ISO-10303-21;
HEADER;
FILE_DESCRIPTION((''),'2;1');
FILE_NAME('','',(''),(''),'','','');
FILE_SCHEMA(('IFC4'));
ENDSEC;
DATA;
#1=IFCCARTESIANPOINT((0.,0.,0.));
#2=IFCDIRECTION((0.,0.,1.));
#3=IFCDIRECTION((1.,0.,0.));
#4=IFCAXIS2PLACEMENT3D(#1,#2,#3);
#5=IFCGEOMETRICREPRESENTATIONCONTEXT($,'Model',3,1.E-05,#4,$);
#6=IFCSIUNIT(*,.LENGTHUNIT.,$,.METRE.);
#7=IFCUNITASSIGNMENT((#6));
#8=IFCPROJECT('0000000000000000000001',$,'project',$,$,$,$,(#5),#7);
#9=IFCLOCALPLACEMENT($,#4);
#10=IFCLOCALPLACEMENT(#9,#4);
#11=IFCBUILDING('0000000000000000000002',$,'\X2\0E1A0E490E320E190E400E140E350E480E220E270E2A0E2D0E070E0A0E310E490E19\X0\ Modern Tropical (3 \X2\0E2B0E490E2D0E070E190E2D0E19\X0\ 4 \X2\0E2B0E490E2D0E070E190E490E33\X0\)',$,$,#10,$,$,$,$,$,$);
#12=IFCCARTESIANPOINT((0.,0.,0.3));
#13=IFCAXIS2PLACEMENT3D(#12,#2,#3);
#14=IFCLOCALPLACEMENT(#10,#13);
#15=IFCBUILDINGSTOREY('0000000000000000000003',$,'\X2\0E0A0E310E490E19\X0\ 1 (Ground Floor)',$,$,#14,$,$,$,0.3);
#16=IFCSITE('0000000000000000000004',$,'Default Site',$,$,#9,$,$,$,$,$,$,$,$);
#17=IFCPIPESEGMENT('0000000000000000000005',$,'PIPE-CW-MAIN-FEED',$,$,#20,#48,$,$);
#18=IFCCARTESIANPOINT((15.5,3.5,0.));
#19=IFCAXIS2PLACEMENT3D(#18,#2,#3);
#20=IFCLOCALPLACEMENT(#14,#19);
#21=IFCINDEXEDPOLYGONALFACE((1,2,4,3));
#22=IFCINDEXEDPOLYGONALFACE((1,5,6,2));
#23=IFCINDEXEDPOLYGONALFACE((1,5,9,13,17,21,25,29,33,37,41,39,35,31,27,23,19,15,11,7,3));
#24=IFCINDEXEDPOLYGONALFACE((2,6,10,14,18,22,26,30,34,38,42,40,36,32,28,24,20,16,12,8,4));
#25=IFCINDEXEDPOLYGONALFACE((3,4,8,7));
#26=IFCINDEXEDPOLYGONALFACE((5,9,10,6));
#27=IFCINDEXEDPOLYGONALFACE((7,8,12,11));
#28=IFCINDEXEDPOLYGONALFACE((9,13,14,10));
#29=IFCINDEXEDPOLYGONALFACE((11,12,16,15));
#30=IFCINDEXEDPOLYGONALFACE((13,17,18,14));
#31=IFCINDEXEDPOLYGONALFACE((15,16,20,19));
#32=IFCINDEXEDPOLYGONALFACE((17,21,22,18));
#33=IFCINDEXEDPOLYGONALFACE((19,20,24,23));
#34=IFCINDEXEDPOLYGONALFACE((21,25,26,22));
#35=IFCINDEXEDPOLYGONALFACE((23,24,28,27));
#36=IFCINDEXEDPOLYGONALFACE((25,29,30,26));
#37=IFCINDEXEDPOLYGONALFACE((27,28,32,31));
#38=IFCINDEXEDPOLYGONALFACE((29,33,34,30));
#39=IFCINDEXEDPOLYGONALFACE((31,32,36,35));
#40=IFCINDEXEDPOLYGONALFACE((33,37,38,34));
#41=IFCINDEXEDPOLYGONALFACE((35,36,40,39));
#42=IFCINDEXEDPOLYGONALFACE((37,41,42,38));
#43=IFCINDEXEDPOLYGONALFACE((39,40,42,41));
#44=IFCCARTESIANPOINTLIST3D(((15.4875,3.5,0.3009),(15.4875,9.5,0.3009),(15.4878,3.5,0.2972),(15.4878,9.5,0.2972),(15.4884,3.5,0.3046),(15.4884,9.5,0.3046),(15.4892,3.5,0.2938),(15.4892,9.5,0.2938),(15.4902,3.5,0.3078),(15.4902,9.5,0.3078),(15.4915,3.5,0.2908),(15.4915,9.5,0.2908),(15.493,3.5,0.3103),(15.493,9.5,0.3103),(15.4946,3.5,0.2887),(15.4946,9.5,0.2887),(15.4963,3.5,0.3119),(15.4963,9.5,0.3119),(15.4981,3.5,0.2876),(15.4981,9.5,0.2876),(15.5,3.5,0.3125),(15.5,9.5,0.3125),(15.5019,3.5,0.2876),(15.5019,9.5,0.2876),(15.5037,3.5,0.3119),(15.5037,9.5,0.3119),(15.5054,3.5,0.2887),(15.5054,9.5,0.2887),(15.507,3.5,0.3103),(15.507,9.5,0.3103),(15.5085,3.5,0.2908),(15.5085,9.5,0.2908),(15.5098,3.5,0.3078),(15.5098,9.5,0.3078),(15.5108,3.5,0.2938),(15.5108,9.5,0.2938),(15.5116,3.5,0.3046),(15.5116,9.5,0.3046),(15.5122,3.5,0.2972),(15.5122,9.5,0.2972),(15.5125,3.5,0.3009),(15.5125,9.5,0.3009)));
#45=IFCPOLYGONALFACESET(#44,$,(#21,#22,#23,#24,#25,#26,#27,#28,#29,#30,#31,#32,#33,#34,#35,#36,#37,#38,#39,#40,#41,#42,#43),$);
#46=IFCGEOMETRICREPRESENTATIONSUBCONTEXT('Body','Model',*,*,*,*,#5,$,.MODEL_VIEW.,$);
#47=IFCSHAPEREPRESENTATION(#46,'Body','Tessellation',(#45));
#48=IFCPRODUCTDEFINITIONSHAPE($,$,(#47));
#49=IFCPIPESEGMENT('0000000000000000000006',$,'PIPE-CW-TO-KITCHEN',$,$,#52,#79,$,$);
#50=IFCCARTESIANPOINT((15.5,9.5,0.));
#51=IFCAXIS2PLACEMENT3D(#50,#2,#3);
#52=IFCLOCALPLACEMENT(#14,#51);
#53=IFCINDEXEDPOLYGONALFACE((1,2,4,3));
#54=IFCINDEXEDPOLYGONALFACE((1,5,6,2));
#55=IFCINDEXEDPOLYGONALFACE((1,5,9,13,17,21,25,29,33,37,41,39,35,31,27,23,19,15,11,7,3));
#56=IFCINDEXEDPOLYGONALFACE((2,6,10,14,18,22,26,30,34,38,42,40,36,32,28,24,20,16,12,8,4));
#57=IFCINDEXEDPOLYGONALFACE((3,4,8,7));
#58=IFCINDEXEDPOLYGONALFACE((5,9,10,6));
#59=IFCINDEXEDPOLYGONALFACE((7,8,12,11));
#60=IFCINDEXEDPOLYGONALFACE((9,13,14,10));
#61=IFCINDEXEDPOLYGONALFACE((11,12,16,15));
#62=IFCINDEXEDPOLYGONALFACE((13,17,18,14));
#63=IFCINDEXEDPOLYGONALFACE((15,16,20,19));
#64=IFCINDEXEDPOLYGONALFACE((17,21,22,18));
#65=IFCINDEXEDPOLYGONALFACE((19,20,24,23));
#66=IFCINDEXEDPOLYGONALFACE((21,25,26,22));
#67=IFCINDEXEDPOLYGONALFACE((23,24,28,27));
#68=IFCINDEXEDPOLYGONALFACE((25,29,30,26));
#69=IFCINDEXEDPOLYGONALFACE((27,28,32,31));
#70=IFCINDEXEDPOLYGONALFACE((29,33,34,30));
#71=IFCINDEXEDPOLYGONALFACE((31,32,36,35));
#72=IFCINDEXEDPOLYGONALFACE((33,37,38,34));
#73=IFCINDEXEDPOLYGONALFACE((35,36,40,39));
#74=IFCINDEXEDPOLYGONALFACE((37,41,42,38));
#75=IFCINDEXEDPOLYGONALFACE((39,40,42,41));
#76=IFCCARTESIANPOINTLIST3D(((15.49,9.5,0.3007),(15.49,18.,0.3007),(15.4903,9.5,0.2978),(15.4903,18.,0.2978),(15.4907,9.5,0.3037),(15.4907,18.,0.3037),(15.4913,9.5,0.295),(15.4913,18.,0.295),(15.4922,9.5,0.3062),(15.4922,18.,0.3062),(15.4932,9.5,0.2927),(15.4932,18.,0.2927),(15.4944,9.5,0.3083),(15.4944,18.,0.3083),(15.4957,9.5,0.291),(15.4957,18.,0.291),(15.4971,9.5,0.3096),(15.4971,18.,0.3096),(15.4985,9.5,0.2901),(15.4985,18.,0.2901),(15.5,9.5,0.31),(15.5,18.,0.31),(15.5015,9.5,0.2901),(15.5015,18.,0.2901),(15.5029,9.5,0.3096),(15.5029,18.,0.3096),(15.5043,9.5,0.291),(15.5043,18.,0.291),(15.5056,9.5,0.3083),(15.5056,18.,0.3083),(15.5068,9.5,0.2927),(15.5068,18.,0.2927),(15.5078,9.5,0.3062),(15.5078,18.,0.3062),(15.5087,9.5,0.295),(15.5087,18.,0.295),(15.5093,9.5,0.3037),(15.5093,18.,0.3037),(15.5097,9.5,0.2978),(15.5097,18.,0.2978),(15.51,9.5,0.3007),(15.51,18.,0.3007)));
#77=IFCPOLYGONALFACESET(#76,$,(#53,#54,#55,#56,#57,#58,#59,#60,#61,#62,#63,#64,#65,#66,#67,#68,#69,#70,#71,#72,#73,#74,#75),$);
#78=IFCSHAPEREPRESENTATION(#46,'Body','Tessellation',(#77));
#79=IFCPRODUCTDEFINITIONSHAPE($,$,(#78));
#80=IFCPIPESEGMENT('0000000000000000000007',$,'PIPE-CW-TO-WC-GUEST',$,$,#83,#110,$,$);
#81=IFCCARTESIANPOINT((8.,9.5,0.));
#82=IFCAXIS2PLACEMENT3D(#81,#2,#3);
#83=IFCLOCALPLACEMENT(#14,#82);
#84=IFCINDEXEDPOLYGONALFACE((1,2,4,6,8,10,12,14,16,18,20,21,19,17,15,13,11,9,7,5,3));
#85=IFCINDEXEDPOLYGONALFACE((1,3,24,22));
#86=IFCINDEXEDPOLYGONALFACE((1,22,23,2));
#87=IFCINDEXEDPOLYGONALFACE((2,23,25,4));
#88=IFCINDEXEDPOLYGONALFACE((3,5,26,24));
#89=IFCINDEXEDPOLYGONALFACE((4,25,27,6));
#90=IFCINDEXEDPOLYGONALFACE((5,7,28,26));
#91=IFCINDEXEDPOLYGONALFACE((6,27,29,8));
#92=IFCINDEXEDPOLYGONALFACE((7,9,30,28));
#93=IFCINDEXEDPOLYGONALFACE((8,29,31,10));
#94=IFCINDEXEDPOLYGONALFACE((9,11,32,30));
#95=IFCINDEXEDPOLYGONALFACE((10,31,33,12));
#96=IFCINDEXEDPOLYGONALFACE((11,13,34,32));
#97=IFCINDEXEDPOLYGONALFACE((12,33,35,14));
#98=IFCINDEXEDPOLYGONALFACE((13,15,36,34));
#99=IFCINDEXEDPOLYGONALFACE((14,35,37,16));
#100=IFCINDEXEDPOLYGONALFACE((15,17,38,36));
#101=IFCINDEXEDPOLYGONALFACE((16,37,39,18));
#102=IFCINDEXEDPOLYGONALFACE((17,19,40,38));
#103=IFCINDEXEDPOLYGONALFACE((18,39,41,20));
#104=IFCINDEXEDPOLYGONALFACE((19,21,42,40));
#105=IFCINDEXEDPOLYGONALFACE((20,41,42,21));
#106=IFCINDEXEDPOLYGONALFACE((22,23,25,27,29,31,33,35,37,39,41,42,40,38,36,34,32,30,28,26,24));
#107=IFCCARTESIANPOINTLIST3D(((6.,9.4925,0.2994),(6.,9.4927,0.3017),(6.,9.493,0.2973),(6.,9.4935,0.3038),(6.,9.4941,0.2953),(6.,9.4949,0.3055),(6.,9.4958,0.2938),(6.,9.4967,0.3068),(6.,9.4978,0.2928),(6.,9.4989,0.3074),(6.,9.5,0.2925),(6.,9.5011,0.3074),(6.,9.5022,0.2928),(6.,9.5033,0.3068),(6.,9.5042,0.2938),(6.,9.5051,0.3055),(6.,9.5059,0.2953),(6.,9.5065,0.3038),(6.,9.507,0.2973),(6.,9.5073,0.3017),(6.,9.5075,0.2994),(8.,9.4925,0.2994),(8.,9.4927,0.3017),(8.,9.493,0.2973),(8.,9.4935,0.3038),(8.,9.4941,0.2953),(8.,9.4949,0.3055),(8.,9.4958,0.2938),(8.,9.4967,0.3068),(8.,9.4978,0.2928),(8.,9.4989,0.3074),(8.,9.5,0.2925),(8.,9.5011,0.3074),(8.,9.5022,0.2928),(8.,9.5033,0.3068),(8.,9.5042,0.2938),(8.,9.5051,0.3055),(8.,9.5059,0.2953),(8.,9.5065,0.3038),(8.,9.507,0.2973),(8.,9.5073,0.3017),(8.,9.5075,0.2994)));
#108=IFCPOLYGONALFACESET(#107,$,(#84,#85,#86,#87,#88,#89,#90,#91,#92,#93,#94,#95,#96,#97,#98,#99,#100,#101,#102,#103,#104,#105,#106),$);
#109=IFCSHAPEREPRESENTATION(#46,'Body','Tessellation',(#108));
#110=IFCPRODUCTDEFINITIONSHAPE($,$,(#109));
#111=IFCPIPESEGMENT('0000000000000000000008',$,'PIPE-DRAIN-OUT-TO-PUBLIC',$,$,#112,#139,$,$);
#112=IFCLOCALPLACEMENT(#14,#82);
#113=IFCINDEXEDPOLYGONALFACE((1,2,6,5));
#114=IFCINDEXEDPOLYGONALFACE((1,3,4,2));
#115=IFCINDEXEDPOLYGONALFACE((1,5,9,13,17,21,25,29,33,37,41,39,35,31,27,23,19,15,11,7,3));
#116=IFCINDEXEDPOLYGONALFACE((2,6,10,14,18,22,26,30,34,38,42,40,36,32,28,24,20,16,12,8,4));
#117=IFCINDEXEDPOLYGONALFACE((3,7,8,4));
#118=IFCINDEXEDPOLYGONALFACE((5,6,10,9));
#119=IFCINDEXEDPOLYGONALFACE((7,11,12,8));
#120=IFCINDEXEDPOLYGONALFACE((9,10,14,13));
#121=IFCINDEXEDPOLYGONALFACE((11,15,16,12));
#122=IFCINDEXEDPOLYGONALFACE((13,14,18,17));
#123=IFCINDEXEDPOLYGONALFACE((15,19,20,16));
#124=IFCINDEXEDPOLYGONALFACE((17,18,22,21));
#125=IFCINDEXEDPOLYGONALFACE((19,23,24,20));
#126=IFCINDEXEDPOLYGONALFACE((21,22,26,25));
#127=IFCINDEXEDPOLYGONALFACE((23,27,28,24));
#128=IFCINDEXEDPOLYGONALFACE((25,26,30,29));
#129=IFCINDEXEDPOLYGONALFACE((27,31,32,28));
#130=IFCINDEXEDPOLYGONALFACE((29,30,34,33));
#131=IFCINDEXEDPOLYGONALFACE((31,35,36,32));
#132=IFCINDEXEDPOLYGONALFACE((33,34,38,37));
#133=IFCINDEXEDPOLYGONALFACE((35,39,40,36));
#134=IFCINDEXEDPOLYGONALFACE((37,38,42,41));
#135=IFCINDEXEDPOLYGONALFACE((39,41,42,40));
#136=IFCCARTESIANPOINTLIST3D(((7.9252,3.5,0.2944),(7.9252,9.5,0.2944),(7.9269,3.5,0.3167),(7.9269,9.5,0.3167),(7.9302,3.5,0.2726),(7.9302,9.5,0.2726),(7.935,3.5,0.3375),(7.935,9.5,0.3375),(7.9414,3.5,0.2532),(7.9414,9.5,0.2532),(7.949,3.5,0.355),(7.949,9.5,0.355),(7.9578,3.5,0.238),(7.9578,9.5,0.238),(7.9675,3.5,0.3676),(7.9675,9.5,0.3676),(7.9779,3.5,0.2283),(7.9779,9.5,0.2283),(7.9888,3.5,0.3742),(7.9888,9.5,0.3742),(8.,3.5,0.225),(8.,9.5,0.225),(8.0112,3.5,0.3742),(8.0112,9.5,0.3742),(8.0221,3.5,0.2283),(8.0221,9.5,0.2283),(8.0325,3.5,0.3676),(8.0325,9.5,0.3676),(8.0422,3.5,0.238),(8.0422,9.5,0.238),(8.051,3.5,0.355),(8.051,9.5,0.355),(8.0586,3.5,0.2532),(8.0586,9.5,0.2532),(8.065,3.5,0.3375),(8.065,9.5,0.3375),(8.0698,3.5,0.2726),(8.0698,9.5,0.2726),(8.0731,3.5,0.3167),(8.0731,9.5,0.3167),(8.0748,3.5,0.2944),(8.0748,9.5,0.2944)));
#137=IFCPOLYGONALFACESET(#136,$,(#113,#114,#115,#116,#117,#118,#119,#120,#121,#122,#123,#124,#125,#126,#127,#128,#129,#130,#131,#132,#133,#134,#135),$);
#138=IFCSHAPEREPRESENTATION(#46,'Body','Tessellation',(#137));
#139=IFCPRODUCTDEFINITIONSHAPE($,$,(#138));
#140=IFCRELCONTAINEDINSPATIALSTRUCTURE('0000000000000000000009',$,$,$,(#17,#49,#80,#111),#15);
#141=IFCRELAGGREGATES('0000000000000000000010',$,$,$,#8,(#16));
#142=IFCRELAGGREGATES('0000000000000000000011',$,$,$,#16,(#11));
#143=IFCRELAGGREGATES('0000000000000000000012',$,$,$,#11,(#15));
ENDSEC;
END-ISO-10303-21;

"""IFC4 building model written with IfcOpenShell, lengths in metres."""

from ifc_helpers import new_model, entity, si_unit, frame, origin_with_axes, place, context, subcontext, project, spatial, element, save


model = new_model("IFC4")

# Units and contexts
model_context = context("Model", 3, precision=1e-05, world=origin_with_axes())
body_context = subcontext(model_context, "Body", "Model", "MODEL_VIEW")
ifc_project = project(units=[si_unit("LENGTHUNIT", "METRE")], contexts=[model_context])

# Site, building, storey
site_placement = place(None, origin_with_axes())
site = spatial("IfcSite", under=ifc_project, at=site_placement, Name="Default Site")
building_placement = place(site_placement, origin_with_axes())
building = spatial("IfcBuilding", under=site, at=building_placement, Name="บ้านเดี่ยวสองชั้น Modern Tropical (3 ห้องนอน 4 ห้องน้ำ)")
storey_placement = place(building_placement, frame((0.0, 0.0, 0.3), z_axis=(0.0, 0.0, 1.0), x_axis=(1.0, 0.0, 0.0)))
storey = spatial("IfcBuildingStorey", under=building, at=storey_placement, Name="ชั้น 1 (Ground Floor)", Elevation=0.3)

# Pipe segments
pipe_segment_1_placement = place(storey_placement, frame((15.5, 3.5, 0.0), z_axis=(0.0, 0.0, 1.0), x_axis=(1.0, 0.0, 0.0)))
element("IfcPipeSegment", 1, at=pipe_segment_1_placement, inside=storey, Name="PIPE-CW-MAIN-FEED", context=body_context, shape_type="SweptSolid", body=[
    entity("IfcSweptDiskSolid", entity("IfcPolyline", [entity("IfcCartesianPoint", [15.5, 3.5, 0.3]), entity("IfcCartesianPoint", [15.5, 9.5, 0.3])]), 0.0125),
])
pipe_segment_2_placement = place(storey_placement, frame((15.5, 9.5, 0.0), z_axis=(0.0, 0.0, 1.0), x_axis=(1.0, 0.0, 0.0)))
element("IfcPipeSegment", 2, at=pipe_segment_2_placement, inside=storey, Name="PIPE-CW-TO-KITCHEN", context=body_context, shape_type="SweptSolid", body=[
    entity("IfcSweptDiskSolid", entity("IfcPolyline", [entity("IfcCartesianPoint", [15.5, 9.5, 0.3]), entity("IfcCartesianPoint", [15.5, 18.0, 0.3])]), 0.01),
])
pipe_segment_3_placement = place(storey_placement, frame((8.0, 9.5, 0.0), z_axis=(0.0, 0.0, 1.0), x_axis=(1.0, 0.0, 0.0)))
element("IfcPipeSegment", 3, at=pipe_segment_3_placement, inside=storey, Name="PIPE-CW-TO-WC-GUEST", context=body_context, shape_type="SweptSolid", body=[
    entity("IfcSweptDiskSolid", entity("IfcPolyline", [entity("IfcCartesianPoint", [8.0, 9.5, 0.3]), entity("IfcCartesianPoint", [6.0, 9.5, 0.3])]), 0.0075),
])
pipe_segment_4_placement = place(storey_placement, frame((8.0, 9.5, 0.0), z_axis=(0.0, 0.0, 1.0), x_axis=(1.0, 0.0, 0.0)))
element("IfcPipeSegment", 4, at=pipe_segment_4_placement, inside=storey, Name="PIPE-DRAIN-OUT-TO-PUBLIC", context=body_context, shape_type="SweptSolid", body=[
    entity("IfcSweptDiskSolid", entity("IfcPolyline", [entity("IfcCartesianPoint", [8.0, 9.5, 0.3]), entity("IfcCartesianPoint", [8.0, 3.5, 0.3])]), 0.075),
])

save(model, "model.ifc")
